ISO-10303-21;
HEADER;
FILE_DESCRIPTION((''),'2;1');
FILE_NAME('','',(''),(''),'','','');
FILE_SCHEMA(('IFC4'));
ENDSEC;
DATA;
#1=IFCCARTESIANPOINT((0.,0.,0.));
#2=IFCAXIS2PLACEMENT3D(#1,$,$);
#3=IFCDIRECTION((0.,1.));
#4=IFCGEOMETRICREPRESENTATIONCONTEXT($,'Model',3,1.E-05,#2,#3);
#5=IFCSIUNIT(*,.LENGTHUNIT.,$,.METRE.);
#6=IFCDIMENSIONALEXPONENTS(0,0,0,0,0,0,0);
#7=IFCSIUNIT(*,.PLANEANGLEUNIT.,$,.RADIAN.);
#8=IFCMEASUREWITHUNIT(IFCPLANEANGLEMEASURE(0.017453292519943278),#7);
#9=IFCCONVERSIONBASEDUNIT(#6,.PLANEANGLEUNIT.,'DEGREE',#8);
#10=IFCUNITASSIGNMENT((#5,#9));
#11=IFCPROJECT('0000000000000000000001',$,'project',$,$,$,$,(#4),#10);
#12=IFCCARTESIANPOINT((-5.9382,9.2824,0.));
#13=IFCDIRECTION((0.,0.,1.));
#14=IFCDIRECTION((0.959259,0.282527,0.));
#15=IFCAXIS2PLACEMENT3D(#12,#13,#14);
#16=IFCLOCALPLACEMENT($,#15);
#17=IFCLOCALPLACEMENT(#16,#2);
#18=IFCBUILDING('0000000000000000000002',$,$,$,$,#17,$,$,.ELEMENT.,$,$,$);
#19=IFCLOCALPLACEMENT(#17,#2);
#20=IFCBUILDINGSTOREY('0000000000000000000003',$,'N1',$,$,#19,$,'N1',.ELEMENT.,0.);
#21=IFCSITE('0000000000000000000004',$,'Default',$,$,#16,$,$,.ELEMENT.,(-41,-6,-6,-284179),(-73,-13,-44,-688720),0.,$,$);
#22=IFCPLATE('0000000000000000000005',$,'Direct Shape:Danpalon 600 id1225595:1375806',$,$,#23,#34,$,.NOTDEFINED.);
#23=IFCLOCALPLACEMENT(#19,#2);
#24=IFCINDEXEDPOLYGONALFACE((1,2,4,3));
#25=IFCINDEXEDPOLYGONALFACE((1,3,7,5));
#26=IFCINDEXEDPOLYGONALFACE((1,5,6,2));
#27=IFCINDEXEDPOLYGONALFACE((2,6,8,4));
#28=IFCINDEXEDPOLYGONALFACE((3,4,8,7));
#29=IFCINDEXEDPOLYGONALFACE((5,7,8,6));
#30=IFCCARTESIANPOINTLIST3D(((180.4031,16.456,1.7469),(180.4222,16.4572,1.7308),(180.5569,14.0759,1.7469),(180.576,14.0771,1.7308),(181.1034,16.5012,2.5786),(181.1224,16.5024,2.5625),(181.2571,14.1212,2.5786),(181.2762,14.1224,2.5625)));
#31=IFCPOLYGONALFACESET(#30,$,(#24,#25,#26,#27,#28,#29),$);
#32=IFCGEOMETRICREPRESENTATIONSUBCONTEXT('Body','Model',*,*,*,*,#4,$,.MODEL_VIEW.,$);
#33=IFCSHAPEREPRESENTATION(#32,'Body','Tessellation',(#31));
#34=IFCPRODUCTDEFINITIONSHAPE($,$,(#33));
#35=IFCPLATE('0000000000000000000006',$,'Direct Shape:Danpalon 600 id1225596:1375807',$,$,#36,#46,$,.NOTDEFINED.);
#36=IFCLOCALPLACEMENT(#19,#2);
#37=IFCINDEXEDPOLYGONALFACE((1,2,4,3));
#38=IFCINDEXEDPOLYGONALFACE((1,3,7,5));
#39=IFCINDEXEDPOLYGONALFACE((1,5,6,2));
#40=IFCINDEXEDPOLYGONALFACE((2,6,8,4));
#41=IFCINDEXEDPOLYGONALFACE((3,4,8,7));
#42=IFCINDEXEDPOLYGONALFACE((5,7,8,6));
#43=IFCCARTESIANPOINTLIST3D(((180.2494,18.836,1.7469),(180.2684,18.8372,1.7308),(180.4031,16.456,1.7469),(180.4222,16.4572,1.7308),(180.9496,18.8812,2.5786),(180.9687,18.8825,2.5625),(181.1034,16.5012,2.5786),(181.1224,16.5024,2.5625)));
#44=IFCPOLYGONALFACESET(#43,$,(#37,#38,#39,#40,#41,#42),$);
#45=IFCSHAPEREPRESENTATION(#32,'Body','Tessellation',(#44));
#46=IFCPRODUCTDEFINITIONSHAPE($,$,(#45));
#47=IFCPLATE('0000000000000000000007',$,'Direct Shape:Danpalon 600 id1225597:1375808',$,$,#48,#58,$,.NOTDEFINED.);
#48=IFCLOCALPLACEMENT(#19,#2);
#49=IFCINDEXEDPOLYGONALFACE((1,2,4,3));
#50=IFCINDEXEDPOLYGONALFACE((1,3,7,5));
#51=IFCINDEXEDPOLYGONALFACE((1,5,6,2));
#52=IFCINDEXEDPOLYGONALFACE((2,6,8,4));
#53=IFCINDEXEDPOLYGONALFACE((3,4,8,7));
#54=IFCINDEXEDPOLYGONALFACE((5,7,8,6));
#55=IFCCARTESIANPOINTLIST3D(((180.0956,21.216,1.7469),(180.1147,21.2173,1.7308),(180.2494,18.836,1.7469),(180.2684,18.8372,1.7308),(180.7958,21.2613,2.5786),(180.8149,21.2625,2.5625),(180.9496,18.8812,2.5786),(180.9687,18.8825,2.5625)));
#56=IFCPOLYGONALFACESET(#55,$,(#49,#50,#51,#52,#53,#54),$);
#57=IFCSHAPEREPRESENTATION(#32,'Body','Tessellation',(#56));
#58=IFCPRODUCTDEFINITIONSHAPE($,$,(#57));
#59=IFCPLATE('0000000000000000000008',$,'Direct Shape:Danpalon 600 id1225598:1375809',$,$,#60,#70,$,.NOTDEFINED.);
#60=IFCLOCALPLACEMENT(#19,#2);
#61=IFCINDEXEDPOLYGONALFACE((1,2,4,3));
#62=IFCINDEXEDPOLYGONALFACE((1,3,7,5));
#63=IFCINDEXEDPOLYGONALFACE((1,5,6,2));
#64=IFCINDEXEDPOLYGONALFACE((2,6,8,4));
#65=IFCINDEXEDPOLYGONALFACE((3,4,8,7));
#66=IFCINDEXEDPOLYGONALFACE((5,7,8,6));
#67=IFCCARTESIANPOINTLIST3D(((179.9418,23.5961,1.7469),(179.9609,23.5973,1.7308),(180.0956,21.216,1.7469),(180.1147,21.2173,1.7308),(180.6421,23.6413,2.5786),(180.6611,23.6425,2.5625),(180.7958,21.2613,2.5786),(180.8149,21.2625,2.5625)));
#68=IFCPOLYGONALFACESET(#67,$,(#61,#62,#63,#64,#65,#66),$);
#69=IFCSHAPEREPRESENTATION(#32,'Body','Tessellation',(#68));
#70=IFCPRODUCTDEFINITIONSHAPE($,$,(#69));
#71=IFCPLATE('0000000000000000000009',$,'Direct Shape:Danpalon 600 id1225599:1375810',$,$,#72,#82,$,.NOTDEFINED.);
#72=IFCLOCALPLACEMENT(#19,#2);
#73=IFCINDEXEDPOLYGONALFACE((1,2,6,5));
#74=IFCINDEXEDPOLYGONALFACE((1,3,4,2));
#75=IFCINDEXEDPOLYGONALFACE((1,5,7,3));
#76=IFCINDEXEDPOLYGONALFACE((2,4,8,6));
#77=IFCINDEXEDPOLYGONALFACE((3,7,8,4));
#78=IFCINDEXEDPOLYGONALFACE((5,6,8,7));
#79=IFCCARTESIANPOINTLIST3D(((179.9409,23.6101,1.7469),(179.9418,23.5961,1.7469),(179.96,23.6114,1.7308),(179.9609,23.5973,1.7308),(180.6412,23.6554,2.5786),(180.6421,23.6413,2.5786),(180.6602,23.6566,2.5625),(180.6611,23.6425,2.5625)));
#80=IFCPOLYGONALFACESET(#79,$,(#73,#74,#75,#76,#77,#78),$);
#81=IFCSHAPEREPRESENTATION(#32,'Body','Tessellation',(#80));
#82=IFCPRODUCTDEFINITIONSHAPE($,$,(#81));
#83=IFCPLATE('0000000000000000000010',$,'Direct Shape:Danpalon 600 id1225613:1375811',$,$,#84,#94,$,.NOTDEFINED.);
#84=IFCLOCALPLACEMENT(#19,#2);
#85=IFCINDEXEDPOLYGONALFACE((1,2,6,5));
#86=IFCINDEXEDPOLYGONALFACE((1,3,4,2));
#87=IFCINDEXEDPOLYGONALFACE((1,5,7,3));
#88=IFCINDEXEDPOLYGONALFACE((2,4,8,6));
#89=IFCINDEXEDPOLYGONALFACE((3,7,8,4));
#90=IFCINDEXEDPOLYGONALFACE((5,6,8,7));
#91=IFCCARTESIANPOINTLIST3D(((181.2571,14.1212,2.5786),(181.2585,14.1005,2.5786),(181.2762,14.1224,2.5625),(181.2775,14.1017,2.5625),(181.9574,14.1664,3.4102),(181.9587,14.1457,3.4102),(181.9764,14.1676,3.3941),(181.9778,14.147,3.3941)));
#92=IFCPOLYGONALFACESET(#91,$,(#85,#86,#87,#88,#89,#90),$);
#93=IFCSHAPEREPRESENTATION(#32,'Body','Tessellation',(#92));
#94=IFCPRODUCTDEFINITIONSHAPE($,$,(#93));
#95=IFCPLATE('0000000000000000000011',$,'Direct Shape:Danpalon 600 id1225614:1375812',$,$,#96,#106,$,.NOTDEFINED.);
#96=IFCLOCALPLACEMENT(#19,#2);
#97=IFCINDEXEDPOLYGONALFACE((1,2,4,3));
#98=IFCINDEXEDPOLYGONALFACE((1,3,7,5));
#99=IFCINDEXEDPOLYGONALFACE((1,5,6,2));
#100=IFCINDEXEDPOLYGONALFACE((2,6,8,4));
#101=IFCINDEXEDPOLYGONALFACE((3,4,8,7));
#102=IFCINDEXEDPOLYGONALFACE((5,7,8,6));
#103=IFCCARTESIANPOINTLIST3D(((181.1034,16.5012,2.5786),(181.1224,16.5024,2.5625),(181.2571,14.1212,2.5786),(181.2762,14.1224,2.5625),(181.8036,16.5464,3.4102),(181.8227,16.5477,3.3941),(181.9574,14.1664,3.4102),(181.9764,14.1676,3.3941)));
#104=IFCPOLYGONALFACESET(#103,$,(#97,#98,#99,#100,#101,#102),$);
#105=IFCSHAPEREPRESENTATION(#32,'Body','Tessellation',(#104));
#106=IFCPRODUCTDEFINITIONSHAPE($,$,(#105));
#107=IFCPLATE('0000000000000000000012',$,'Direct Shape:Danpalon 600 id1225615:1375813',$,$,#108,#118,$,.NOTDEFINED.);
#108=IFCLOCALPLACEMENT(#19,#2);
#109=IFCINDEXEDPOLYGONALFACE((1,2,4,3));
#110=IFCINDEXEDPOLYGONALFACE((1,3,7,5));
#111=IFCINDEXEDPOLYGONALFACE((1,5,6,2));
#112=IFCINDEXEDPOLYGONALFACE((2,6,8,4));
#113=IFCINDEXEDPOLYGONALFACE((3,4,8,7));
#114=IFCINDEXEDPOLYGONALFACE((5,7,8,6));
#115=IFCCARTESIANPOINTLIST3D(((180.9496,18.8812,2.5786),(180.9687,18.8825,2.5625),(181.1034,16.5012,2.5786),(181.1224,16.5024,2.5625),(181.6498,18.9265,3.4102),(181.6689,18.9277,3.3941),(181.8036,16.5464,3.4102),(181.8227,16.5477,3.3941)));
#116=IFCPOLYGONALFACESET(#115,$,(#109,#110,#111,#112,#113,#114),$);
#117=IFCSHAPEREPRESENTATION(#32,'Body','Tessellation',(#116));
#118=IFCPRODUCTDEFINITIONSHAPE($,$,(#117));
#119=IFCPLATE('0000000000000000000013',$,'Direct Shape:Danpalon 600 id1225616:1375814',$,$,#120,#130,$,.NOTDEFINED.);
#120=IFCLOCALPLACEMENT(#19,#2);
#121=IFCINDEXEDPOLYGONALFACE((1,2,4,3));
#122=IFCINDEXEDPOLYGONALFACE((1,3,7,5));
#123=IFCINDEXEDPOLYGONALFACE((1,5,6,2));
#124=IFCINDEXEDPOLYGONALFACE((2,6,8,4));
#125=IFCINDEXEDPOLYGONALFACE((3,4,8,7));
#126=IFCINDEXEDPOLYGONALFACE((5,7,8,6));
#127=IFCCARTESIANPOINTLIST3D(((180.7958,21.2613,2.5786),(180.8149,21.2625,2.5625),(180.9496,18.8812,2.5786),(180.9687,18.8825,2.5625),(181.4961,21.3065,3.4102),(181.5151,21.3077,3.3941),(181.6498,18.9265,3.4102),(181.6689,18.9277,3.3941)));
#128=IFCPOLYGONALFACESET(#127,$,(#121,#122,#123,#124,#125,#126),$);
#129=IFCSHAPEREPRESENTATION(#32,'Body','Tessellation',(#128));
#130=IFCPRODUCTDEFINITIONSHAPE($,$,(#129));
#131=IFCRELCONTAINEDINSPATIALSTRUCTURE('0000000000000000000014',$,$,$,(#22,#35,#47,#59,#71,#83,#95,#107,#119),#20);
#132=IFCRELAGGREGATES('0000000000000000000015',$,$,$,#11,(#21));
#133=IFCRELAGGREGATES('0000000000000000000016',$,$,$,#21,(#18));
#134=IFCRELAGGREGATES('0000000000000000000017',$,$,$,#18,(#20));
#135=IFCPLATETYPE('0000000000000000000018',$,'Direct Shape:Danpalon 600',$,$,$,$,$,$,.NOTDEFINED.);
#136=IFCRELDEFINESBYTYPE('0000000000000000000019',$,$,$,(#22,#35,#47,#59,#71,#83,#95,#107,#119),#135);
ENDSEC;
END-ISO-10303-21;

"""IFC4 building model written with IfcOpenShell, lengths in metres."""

from ifc_helpers import new_model, entity, si_unit, converted_unit, direction, frame, frame_2d, origin, place, context, subcontext, project, spatial, rectangle, extrude, type_object, element, save


model = new_model("IFC4")

# Units and contexts
model_context = context("Model", 3, precision=1e-05, world=origin(), true_north=direction((0.0, 1.0)))
body_context = subcontext(model_context, "Body", "Model", "MODEL_VIEW")
ifc_project = project(units=[si_unit("LENGTHUNIT", "METRE"), converted_unit("PLANEANGLEUNIT", "DEGREE", entity("IfcPlaneAngleMeasure", 0.017453292519943278), si_unit("PLANEANGLEUNIT", "RADIAN"), dimensions=[0, 0, 0, 0, 0, 0, 0])], contexts=[model_context])

# Site, building, storey
site_placement = place(None, frame((-5.9382, 9.2824, 0.0), z_axis=(0.0, 0.0, 1.0), x_axis=(0.959259, 0.282527, 0.0)))
site = spatial("IfcSite", under=ifc_project, at=site_placement, Name="Default", CompositionType="ELEMENT", RefLatitude=(-41, -6, -6, -284179), RefLongitude=(-73, -13, -44, -688720), RefElevation=0.0)
building_placement = place(site_placement, origin())
building = spatial("IfcBuilding", under=site, at=building_placement, CompositionType="ELEMENT")
storey_placement = place(building_placement, origin())
storey = spatial("IfcBuildingStorey", under=building, at=storey_placement, Name="N1", LongName="N1", CompositionType="ELEMENT", Elevation=0.0)

# Plates
plate_type = type_object("IfcPlateType", Name="Direct Shape:Danpalon 600", PredefinedType="NOTDEFINED")
plate_1_placement = place(storey_placement, origin())
element("IfcPlate", 1, at=plate_1_placement, inside=storey, type_object=plate_type, Name="Direct Shape:Danpalon 600 id1225595:1375806", PredefinedType="NOTDEFINED", context=body_context, shape_type="SweptSolid", body=[
    extrude(rectangle(XDim=1.0881, YDim=0.025, at=frame_2d((0.0, 0.0), x_axis=(0.0, 1.0))), frame((180.9165, 14.0991, 2.1547), z_axis=(-0.064471, 0.99792, 0.0), x_axis=(-0.762714, -0.049276, 0.644857)), (0.0, 0.0, 1.0), 2.385),
])
plate_2_placement = place(storey_placement, origin())
element("IfcPlate", 2, at=plate_2_placement, inside=storey, type_object=plate_type, Name="Direct Shape:Danpalon 600 id1225596:1375807", PredefinedType="NOTDEFINED", context=body_context, shape_type="SweptSolid", body=[
    extrude(rectangle(XDim=1.0881, YDim=0.025, at=frame_2d((0.0, 0.0), x_axis=(0.0, 1.0))), frame((180.7628, 16.4792, 2.1547), z_axis=(-0.064471, 0.99792, 0.0), x_axis=(-0.762714, -0.049276, 0.644857)), (0.0, 0.0, 1.0), 2.385),
])
plate_3_placement = place(storey_placement, origin())
element("IfcPlate", 3, at=plate_3_placement, inside=storey, type_object=plate_type, Name="Direct Shape:Danpalon 600 id1225597:1375808", PredefinedType="NOTDEFINED", context=body_context, shape_type="SweptSolid", body=[
    extrude(rectangle(XDim=1.0881, YDim=0.025, at=frame_2d((0.0, 0.0), x_axis=(0.0, 1.0))), frame((180.609, 18.8592, 2.1547), z_axis=(-0.064471, 0.99792, 0.0), x_axis=(-0.762714, -0.049276, 0.644857)), (0.0, 0.0, 1.0), 2.385),
])
plate_4_placement = place(storey_placement, origin())
element("IfcPlate", 4, at=plate_4_placement, inside=storey, type_object=plate_type, Name="Direct Shape:Danpalon 600 id1225598:1375809", PredefinedType="NOTDEFINED", context=body_context, shape_type="SweptSolid", body=[
    extrude(rectangle(XDim=1.0881, YDim=0.025, at=frame_2d((0.0, 0.0), x_axis=(0.0, 1.0))), frame((180.4553, 21.2393, 2.1547), z_axis=(-0.064471, 0.99792, 0.0), x_axis=(-0.762714, -0.049276, 0.644857)), (0.0, 0.0, 1.0), 2.385),
])
plate_5_placement = place(storey_placement, origin())
element("IfcPlate", 5, at=plate_5_placement, inside=storey, type_object=plate_type, Name="Direct Shape:Danpalon 600 id1225599:1375810", PredefinedType="NOTDEFINED", context=body_context, shape_type="SweptSolid", body=[
    extrude(rectangle(XDim=0.025, YDim=0.0141, at=frame_2d((0.0, 0.0), x_axis=(0.0, 1.0))), frame((179.9509, 23.6037, 1.7389), z_axis=(0.643515, 0.041575, 0.764304), x_axis=(0.064471, -0.99792, 0.0)), (0.0, 0.0, 1.0), 1.0881),
])
plate_6_placement = place(storey_placement, origin())
element("IfcPlate", 6, at=plate_6_placement, inside=storey, type_object=plate_type, Name="Direct Shape:Danpalon 600 id1225613:1375811", PredefinedType="NOTDEFINED", context=body_context, shape_type="SweptSolid", body=[
    extrude(rectangle(XDim=0.025, YDim=0.0207, at=frame_2d((0.0, 0.0), x_axis=(0.0, 1.0))), frame((181.2673, 14.1114, 2.5705), z_axis=(0.643515, 0.041575, 0.764304), x_axis=(-0.064471, 0.99792, 0.0)), (0.0, 0.0, 1.0), 1.0881),
])
plate_7_placement = place(storey_placement, origin())
element("IfcPlate", 7, at=plate_7_placement, inside=storey, type_object=plate_type, Name="Direct Shape:Danpalon 600 id1225614:1375812", PredefinedType="NOTDEFINED", context=body_context, shape_type="SweptSolid", body=[
    extrude(rectangle(XDim=1.0881, YDim=0.025, at=frame_2d((0.0, 0.0), x_axis=(0.0, 1.0))), frame((181.6168, 14.1444, 2.9864), z_axis=(-0.064471, 0.99792, 0.0), x_axis=(-0.762714, -0.049276, 0.644857)), (0.0, 0.0, 1.0), 2.385),
])
plate_8_placement = place(storey_placement, origin())
element("IfcPlate", 8, at=plate_8_placement, inside=storey, type_object=plate_type, Name="Direct Shape:Danpalon 600 id1225615:1375813", PredefinedType="NOTDEFINED", context=body_context, shape_type="SweptSolid", body=[
    extrude(rectangle(XDim=1.0881, YDim=0.025, at=frame_2d((0.0, 0.0), x_axis=(0.0, 1.0))), frame((181.463, 16.5244, 2.9864), z_axis=(-0.064471, 0.99792, 0.0), x_axis=(-0.762714, -0.049276, 0.644857)), (0.0, 0.0, 1.0), 2.385),
])
plate_9_placement = place(storey_placement, origin())
element("IfcPlate", 9, at=plate_9_placement, inside=storey, type_object=plate_type, Name="Direct Shape:Danpalon 600 id1225616:1375814", PredefinedType="NOTDEFINED", context=body_context, shape_type="SweptSolid", body=[
    extrude(rectangle(XDim=1.0881, YDim=0.025, at=frame_2d((0.0, 0.0), x_axis=(0.0, 1.0))), frame((181.3093, 18.9045, 2.9864), z_axis=(-0.064471, 0.99792, 0.0), x_axis=(-0.762714, -0.049276, 0.644857)), (0.0, 0.0, 1.0), 2.385),
])

save(model, "model.ifc")
